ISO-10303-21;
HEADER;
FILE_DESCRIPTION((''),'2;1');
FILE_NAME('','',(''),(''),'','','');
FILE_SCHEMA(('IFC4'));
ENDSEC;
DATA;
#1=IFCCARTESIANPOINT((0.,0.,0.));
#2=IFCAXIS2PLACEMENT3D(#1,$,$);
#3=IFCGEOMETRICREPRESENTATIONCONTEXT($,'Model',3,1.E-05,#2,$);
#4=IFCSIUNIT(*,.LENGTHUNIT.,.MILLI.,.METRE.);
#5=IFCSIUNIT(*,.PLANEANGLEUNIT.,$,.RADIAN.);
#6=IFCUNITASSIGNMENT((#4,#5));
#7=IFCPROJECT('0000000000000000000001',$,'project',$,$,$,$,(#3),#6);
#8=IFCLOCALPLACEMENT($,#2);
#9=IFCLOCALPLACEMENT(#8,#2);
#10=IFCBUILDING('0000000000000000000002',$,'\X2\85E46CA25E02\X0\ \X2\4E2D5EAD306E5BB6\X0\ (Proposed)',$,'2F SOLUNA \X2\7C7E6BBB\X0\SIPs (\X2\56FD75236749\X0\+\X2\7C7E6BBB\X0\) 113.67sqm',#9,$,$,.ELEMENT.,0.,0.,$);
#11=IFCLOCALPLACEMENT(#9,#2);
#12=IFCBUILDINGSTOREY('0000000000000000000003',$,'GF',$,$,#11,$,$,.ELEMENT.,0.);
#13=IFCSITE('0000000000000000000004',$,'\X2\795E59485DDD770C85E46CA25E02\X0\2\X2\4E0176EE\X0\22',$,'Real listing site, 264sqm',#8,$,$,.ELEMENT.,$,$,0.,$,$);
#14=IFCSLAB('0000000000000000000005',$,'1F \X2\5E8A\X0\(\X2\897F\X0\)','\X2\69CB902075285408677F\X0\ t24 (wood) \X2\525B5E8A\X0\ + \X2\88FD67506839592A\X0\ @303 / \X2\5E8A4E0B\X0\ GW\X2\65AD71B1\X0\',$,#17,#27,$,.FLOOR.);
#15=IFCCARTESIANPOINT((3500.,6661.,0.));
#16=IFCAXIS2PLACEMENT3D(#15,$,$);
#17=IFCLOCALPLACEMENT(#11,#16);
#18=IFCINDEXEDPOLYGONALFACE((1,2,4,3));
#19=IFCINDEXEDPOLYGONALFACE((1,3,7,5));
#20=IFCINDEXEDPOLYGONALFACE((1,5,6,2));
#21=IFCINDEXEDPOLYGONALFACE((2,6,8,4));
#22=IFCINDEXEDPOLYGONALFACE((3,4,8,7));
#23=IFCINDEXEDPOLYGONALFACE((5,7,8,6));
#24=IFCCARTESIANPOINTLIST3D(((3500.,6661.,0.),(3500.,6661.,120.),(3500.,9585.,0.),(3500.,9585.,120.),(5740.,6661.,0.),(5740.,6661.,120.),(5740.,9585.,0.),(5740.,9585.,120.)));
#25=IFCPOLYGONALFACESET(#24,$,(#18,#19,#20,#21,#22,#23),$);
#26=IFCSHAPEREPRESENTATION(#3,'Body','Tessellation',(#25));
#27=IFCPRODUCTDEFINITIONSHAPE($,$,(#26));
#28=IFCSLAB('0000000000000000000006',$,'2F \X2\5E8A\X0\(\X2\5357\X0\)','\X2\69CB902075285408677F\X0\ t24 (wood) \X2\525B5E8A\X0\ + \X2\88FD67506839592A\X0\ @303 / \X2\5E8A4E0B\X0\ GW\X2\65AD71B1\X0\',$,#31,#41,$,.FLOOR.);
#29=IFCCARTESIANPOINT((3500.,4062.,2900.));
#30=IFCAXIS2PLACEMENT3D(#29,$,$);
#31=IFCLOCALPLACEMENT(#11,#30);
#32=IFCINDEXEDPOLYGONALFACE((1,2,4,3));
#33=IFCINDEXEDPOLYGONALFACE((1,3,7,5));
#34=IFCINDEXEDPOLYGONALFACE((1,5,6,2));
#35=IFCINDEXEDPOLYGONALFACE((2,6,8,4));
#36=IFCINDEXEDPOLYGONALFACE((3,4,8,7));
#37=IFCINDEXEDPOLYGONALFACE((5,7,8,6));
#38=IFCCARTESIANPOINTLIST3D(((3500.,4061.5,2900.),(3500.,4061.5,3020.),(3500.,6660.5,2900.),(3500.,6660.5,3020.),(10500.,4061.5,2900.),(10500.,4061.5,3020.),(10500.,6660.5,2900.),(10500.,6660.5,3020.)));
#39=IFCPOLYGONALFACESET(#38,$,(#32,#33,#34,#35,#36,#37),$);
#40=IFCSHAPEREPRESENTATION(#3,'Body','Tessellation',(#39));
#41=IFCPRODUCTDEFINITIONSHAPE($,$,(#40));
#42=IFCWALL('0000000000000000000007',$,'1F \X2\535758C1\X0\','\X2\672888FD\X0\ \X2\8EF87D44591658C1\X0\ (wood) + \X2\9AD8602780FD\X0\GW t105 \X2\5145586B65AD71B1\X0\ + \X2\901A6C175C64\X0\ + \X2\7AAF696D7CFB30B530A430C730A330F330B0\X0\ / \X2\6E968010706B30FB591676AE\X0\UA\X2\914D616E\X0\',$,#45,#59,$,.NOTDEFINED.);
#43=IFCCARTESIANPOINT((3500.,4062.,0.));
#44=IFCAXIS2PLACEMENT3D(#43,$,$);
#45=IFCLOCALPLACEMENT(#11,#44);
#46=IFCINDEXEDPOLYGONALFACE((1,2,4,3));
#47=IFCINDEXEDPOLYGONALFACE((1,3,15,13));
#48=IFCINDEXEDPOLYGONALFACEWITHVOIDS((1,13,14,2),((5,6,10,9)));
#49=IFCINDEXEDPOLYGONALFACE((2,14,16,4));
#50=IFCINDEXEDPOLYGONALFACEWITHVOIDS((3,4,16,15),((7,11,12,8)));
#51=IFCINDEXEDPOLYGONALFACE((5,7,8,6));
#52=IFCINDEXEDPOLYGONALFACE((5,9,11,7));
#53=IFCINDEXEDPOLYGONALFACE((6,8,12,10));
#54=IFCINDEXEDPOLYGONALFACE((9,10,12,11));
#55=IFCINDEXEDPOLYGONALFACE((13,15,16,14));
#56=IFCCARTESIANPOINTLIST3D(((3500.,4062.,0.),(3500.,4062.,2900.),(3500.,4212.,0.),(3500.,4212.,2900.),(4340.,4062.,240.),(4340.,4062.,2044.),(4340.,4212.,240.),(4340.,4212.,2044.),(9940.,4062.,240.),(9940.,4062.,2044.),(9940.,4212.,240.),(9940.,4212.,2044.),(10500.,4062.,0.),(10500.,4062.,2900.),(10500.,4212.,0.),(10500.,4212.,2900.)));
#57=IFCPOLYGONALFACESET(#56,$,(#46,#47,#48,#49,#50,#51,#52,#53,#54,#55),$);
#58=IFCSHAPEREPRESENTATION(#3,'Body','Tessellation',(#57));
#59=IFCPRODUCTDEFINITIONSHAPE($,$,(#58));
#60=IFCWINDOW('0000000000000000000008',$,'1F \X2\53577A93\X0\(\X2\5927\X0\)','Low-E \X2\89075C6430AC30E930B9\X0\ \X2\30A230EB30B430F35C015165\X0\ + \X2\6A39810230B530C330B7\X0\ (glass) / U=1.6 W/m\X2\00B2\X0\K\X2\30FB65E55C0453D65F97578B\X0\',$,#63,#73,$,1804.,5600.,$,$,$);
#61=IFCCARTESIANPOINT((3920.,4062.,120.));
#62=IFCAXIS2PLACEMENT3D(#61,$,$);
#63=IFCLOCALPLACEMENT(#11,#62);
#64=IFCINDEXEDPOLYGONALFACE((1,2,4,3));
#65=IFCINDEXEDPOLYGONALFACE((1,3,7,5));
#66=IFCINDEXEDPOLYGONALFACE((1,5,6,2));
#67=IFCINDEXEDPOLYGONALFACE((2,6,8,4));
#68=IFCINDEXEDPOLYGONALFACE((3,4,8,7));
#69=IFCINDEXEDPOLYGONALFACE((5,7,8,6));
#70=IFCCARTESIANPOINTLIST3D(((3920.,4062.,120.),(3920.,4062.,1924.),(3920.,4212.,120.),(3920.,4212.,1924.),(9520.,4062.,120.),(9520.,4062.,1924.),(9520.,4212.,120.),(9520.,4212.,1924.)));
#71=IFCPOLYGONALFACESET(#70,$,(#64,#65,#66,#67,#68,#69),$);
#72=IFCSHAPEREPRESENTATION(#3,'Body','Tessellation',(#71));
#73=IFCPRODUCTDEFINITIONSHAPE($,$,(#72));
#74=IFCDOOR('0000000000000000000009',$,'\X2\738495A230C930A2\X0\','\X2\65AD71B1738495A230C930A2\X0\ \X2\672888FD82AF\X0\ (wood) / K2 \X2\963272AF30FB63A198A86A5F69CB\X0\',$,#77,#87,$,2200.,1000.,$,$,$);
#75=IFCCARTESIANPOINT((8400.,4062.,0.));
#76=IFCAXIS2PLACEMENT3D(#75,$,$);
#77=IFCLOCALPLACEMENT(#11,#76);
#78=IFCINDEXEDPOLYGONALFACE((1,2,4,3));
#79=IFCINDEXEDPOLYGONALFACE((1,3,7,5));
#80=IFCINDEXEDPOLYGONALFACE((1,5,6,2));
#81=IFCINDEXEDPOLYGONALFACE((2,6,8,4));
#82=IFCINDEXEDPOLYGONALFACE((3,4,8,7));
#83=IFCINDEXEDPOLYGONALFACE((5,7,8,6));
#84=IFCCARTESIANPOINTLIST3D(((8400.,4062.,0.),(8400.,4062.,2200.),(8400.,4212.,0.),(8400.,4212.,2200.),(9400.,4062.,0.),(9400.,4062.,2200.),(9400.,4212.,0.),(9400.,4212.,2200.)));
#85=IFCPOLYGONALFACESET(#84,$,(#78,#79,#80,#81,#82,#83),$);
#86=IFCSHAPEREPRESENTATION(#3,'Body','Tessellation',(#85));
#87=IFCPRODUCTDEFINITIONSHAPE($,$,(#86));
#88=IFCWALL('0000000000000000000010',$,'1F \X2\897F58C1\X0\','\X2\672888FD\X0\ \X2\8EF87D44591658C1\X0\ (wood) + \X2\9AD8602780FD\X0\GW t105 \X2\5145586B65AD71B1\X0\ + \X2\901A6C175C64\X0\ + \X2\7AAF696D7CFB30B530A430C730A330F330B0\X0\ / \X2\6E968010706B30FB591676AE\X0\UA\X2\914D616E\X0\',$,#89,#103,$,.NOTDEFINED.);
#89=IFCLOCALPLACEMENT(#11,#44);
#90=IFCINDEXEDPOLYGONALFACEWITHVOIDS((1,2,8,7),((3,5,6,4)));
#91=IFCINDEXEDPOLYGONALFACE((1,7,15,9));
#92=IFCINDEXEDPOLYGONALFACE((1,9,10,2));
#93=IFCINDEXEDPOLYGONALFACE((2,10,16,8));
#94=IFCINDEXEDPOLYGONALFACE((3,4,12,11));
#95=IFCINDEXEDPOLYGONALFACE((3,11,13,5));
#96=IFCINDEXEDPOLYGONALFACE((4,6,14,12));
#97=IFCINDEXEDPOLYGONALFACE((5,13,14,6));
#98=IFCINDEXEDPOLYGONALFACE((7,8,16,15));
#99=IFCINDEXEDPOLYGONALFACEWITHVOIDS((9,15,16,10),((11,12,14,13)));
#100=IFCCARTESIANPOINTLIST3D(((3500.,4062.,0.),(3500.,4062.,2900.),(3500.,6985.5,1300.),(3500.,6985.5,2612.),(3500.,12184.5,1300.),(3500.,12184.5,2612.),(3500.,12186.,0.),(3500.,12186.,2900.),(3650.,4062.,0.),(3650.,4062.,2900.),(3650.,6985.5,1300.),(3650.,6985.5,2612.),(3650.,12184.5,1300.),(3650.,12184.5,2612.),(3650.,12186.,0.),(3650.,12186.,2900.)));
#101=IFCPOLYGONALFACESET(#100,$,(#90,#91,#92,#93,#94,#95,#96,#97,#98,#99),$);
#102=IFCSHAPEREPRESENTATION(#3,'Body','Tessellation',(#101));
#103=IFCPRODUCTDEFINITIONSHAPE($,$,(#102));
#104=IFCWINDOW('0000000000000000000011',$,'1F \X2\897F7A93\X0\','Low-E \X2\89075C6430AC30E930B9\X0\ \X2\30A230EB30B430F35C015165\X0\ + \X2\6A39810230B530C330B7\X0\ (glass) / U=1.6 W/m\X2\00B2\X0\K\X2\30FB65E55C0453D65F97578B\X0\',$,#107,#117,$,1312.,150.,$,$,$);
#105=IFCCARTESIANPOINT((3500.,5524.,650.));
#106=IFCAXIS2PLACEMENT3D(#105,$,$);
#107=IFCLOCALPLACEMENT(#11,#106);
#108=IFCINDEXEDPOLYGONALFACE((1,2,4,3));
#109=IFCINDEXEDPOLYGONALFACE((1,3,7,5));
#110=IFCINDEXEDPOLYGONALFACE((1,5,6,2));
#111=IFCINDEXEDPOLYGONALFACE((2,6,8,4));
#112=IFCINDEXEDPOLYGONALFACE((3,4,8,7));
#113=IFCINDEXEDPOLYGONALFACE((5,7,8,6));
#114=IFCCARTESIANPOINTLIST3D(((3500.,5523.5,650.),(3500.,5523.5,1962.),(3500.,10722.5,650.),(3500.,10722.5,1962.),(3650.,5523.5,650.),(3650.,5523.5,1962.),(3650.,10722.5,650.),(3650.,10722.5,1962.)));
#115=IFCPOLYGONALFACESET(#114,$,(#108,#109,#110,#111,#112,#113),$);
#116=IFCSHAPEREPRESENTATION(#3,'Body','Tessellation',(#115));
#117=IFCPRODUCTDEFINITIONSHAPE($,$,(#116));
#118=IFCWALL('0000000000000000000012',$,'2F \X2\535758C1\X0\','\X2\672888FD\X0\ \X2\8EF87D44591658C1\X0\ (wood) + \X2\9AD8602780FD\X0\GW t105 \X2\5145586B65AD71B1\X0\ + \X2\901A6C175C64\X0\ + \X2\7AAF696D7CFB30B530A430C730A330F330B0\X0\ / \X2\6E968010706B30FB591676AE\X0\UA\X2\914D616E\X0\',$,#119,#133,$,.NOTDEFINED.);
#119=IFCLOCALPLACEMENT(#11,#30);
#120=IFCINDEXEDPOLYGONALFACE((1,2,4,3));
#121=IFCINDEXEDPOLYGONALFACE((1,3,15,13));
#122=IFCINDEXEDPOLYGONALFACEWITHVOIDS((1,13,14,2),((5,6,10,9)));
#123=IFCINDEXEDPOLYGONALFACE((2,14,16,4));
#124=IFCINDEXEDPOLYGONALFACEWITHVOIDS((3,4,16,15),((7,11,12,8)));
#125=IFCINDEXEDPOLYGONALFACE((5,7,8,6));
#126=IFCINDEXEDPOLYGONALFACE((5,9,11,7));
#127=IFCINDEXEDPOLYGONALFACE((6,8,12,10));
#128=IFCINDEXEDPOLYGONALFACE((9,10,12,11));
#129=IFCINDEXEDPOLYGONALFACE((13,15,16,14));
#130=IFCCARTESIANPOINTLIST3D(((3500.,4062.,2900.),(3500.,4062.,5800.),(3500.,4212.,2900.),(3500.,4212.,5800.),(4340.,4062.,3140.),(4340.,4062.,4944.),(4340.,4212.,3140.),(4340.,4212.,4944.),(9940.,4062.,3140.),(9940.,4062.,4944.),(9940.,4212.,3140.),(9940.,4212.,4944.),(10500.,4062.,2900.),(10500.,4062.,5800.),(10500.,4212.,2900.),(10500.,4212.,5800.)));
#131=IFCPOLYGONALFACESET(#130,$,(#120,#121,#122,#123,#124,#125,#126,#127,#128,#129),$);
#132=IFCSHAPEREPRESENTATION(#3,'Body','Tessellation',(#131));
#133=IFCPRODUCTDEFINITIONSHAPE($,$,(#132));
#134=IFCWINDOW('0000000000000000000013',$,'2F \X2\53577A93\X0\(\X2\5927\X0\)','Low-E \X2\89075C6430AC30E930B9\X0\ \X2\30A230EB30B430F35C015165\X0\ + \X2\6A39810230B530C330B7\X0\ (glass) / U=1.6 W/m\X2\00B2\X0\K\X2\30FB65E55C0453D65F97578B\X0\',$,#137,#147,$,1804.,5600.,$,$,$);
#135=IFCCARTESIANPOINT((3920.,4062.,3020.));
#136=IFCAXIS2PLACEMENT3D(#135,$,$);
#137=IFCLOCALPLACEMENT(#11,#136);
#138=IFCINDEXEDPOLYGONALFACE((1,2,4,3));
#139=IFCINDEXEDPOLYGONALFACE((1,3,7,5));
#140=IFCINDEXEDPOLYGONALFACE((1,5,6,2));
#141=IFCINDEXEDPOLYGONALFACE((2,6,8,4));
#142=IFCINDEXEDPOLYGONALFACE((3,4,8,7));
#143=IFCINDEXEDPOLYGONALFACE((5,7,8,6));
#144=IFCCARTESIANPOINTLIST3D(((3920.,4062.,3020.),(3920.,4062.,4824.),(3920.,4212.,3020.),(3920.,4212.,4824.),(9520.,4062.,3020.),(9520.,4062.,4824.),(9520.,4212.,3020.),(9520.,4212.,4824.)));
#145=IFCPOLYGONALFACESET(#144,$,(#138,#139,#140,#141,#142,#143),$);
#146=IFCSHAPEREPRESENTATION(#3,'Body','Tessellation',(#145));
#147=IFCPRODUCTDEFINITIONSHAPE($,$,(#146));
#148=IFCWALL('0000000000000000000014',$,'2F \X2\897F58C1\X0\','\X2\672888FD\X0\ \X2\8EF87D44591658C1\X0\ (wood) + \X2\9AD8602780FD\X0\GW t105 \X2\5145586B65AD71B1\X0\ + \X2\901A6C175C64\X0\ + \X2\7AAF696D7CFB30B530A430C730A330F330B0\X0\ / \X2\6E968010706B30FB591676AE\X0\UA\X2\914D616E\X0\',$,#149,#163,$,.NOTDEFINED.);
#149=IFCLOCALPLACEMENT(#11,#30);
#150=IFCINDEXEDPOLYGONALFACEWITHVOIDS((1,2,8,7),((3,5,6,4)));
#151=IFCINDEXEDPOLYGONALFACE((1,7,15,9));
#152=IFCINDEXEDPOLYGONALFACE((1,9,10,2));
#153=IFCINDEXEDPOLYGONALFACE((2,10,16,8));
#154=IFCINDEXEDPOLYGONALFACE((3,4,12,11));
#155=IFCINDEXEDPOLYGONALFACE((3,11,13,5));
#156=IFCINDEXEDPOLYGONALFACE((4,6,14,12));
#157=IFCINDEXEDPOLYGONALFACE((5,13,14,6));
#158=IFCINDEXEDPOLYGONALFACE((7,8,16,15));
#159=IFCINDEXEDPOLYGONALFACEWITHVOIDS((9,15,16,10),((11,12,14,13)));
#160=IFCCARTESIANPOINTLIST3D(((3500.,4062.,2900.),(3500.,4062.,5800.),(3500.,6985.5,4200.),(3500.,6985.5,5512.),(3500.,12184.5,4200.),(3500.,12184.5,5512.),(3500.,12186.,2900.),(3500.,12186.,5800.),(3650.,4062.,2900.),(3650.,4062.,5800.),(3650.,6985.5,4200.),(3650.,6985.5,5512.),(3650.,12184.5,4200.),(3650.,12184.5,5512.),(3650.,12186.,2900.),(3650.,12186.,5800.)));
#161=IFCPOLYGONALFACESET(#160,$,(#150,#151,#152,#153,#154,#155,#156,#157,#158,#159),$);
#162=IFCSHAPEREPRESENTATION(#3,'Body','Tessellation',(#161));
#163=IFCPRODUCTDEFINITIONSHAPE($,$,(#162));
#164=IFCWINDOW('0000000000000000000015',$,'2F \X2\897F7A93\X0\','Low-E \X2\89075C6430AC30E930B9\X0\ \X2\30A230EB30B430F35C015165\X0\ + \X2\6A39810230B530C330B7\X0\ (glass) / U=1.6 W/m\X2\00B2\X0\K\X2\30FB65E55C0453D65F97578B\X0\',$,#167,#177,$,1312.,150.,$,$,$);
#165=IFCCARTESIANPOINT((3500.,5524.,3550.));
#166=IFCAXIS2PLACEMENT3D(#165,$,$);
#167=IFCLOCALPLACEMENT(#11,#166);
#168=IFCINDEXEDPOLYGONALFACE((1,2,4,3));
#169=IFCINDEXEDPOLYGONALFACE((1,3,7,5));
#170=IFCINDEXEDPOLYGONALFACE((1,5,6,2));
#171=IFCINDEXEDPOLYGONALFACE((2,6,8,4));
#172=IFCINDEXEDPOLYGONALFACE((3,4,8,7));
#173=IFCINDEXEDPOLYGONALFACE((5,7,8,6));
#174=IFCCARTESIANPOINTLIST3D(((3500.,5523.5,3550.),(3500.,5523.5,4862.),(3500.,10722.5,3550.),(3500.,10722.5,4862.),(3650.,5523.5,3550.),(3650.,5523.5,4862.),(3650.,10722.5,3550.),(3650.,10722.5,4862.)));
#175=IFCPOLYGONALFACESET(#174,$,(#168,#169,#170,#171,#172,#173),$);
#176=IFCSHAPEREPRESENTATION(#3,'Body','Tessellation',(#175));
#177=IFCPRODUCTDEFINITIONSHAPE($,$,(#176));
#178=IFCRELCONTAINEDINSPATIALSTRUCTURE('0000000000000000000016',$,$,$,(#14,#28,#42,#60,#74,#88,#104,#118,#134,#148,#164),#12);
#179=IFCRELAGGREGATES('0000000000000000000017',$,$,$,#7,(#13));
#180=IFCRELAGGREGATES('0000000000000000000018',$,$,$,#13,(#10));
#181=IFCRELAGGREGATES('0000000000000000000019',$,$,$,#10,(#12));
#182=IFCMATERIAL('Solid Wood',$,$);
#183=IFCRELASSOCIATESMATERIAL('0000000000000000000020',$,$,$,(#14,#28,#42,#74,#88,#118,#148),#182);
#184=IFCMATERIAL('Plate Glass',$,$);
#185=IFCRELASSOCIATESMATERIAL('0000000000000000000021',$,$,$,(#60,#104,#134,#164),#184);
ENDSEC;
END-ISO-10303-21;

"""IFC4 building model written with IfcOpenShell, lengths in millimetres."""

from ifc_helpers import new_model, si_unit, frame, frame_2d, origin, place, context, project, spatial, rectangle, extrude, material, element, fill, save


model = new_model("IFC4")

# Units and contexts
model_context = context("Model", 3, precision=1e-05, world=origin())
ifc_project = project(units=[si_unit("LENGTHUNIT", "METRE", prefix="MILLI"), si_unit("PLANEANGLEUNIT", "RADIAN")], contexts=[model_context])

# Site, building, storey
site_placement = place(None, origin())
site = spatial("IfcSite", under=ifc_project, at=site_placement, Name="神奈川県藤沢市2丁目22", ObjectType="Real listing site, 264sqm", CompositionType="ELEMENT", RefElevation=0.0)
building_placement = place(site_placement, origin())
building = spatial("IfcBuilding", under=site, at=building_placement, Name="藤沢市 中庭の家 (Proposed)", ObjectType="2F SOLUNA 籾殻SIPs (国産杉+籾殻) 113.67sqm", CompositionType="ELEMENT", ElevationOfRefHeight=0.0, ElevationOfTerrain=0.0)
storey_placement = place(building_placement, origin())
storey = spatial("IfcBuildingStorey", under=building, at=storey_placement, Name="GF", CompositionType="ELEMENT", Elevation=0.0)

# Slabs
ifc_material_1 = material(Name="Solid Wood")
slab_1_placement = place(storey_placement, frame((3500.0, 6661.0, 0.0)))
element("IfcSlab", 1, at=slab_1_placement, inside=storey, material=ifc_material_1, Name="1F 床(西)", Description="構造用合板 t24 (wood) 剛床 + 製材根太 @303 / 床下 GW断熱", PredefinedType="FLOOR", context=model_context, shape_type="SweptSolid", body=[
    extrude(rectangle(XDim=2240.0, YDim=2924.0, at=frame_2d((1120.0, 1462.0))), frame((3500.0, 6661.0, 0.0)), (0.0, 0.0, 1.0), 120.0),
])
slab_2_placement = place(storey_placement, frame((3500.0, 4062.0, 2900.0)))
element("IfcSlab", 2, at=slab_2_placement, inside=storey, material=ifc_material_1, Name="2F 床(南)", Description="構造用合板 t24 (wood) 剛床 + 製材根太 @303 / 床下 GW断熱", PredefinedType="FLOOR", context=model_context, shape_type="SweptSolid", body=[
    extrude(rectangle(XDim=7000.0, YDim=2599.0, at=frame_2d((3500.0, 1299.0))), frame((3500.0, 4062.0, 2900.0)), (0.0, 0.0, 1.0), 120.0),
])

# Wall, openings, window, door
wall_1_placement = place(storey_placement, frame((3500.0, 4062.0, 0.0)))
wall_1 = element("IfcWall", 3, at=wall_1_placement, inside=storey, material=ifc_material_1, Name="1F 南壁", Description="木製 軸組外壁 (wood) + 高性能GW t105 充填断熱 + 通気層 + 窯業系サイディング / 準耐火・外皮UA配慮", PredefinedType="NOTDEFINED", context=model_context, shape_type="SweptSolid", body=[
    extrude(rectangle(XDim=7000.0, YDim=150.0, at=frame_2d((3500.0, 75.0))), frame((3500.0, 4062.0, 0.0)), (0.0, 0.0, 1.0), 2900.0),
])
opening_1_placement = place(storey_placement, frame((3920.0, 4062.0, 120.0)))
opening_1 = element("IfcOpeningElement", 4, at=opening_1_placement, cuts=wall_1, PredefinedType="NOTDEFINED", context=model_context, shape_type="SweptSolid", body=[
    extrude(rectangle(XDim=5600.0, YDim=150.0, at=frame_2d((2800.0, 75.0))), frame((3920.0, 4062.0, 120.0)), (0.0, 0.0, 1.0), 1804.0),
])
opening_2_placement = place(storey_placement, frame((8400.0, 4062.0, 0.0)))
opening_2 = element("IfcOpeningElement", 5, at=opening_2_placement, cuts=wall_1, PredefinedType="NOTDEFINED", context=model_context, shape_type="SweptSolid", body=[
    extrude(rectangle(XDim=1000.0, YDim=150.0, at=frame_2d((500.0, 75.0))), frame((8400.0, 4062.0, 0.0)), (0.0, 0.0, 1.0), 2200.0),
])
ifc_material_2 = material(Name="Plate Glass")
window_1_placement = place(storey_placement, frame((3920.0, 4062.0, 120.0)))
window_1 = element("IfcWindow", 6, at=window_1_placement, inside=storey, material=ifc_material_2, Name="1F 南窓(大)", Description="Low-E 複層ガラス アルゴン封入 + 樹脂サッシ (glass) / U=1.6 W/m²K・日射取得型", OverallHeight=1804.0, OverallWidth=5600.0, context=model_context, shape_type="SweptSolid", body=[
    extrude(rectangle(XDim=5600.0, YDim=150.0, at=frame_2d((2800.0, 75.0))), frame((3920.0, 4062.0, 120.0)), (0.0, 0.0, 1.0), 1804.0),
])
fill(opening_1, window_1)
door_placement = place(storey_placement, frame((8400.0, 4062.0, 0.0)))
door = element("IfcDoor", 7, at=door_placement, inside=storey, material=ifc_material_1, Name="玄関ドア", Description="断熱玄関ドア 木製芯 (wood) / K2 防犯・採風機構", OverallHeight=2200.0, OverallWidth=1000.0, context=model_context, shape_type="SweptSolid", body=[
    extrude(rectangle(XDim=1000.0, YDim=150.0, at=frame_2d((500.0, 75.0))), frame((8400.0, 4062.0, 0.0)), (0.0, 0.0, 1.0), 2200.0),
])
fill(opening_2, door)

# Walls, openings, windows
wall_2_placement = place(storey_placement, frame((3500.0, 4062.0, 0.0)))
wall_2 = element("IfcWall", 8, at=wall_2_placement, inside=storey, material=ifc_material_1, Name="1F 西壁", Description="木製 軸組外壁 (wood) + 高性能GW t105 充填断熱 + 通気層 + 窯業系サイディング / 準耐火・外皮UA配慮", PredefinedType="NOTDEFINED", context=model_context, shape_type="SweptSolid", body=[
    extrude(rectangle(XDim=150.0, YDim=8124.0, at=frame_2d((75.0, 4062.0))), frame((3500.0, 4062.0, 0.0)), (0.0, 0.0, 1.0), 2900.0),
])
opening_3_placement = place(storey_placement, frame((3500.0, 5524.0, 650.0)))
opening_3 = element("IfcOpeningElement", 9, at=opening_3_placement, cuts=wall_2, PredefinedType="NOTDEFINED", context=model_context, shape_type="SweptSolid", body=[
    extrude(rectangle(XDim=150.0, YDim=5199.0, at=frame_2d((75.0, 2599.0))), frame((3500.0, 5524.0, 650.0)), (0.0, 0.0, 1.0), 1312.0),
])
window_2_placement = place(storey_placement, frame((3500.0, 5524.0, 650.0)))
window_2 = element("IfcWindow", 10, at=window_2_placement, inside=storey, material=ifc_material_2, Name="1F 西窓", Description="Low-E 複層ガラス アルゴン封入 + 樹脂サッシ (glass) / U=1.6 W/m²K・日射取得型", OverallHeight=1312.0, OverallWidth=150.0, context=model_context, shape_type="SweptSolid", body=[
    extrude(rectangle(XDim=150.0, YDim=5199.0, at=frame_2d((75.0, 2599.0))), frame((3500.0, 5524.0, 650.0)), (0.0, 0.0, 1.0), 1312.0),
])
fill(opening_3, window_2)
wall_3_placement = place(storey_placement, frame((3500.0, 4062.0, 2900.0)))
wall_3 = element("IfcWall", 11, at=wall_3_placement, inside=storey, material=ifc_material_1, Name="2F 南壁", Description="木製 軸組外壁 (wood) + 高性能GW t105 充填断熱 + 通気層 + 窯業系サイディング / 準耐火・外皮UA配慮", PredefinedType="NOTDEFINED", context=model_context, shape_type="SweptSolid", body=[
    extrude(rectangle(XDim=7000.0, YDim=150.0, at=frame_2d((3500.0, 75.0))), frame((3500.0, 4062.0, 2900.0)), (0.0, 0.0, 1.0), 2900.0),
])
opening_4_placement = place(storey_placement, frame((3920.0, 4062.0, 3020.0)))
opening_4 = element("IfcOpeningElement", 12, at=opening_4_placement, cuts=wall_3, PredefinedType="NOTDEFINED", context=model_context, shape_type="SweptSolid", body=[
    extrude(rectangle(XDim=5600.0, YDim=150.0, at=frame_2d((2800.0, 75.0))), frame((3920.0, 4062.0, 3020.0)), (0.0, 0.0, 1.0), 1804.0),
])
window_3_placement = place(storey_placement, frame((3920.0, 4062.0, 3020.0)))
window_3 = element("IfcWindow", 13, at=window_3_placement, inside=storey, material=ifc_material_2, Name="2F 南窓(大)", Description="Low-E 複層ガラス アルゴン封入 + 樹脂サッシ (glass) / U=1.6 W/m²K・日射取得型", OverallHeight=1804.0, OverallWidth=5600.0, context=model_context, shape_type="SweptSolid", body=[
    extrude(rectangle(XDim=5600.0, YDim=150.0, at=frame_2d((2800.0, 75.0))), frame((3920.0, 4062.0, 3020.0)), (0.0, 0.0, 1.0), 1804.0),
])
fill(opening_4, window_3)
wall_4_placement = place(storey_placement, frame((3500.0, 4062.0, 2900.0)))
wall_4 = element("IfcWall", 14, at=wall_4_placement, inside=storey, material=ifc_material_1, Name="2F 西壁", Description="木製 軸組外壁 (wood) + 高性能GW t105 充填断熱 + 通気層 + 窯業系サイディング / 準耐火・外皮UA配慮", PredefinedType="NOTDEFINED", context=model_context, shape_type="SweptSolid", body=[
    extrude(rectangle(XDim=150.0, YDim=8124.0, at=frame_2d((75.0, 4062.0))), frame((3500.0, 4062.0, 2900.0)), (0.0, 0.0, 1.0), 2900.0),
])
opening_5_placement = place(storey_placement, frame((3500.0, 5524.0, 3550.0)))
opening_5 = element("IfcOpeningElement", 15, at=opening_5_placement, cuts=wall_4, PredefinedType="NOTDEFINED", context=model_context, shape_type="SweptSolid", body=[
    extrude(rectangle(XDim=150.0, YDim=5199.0, at=frame_2d((75.0, 2599.0))), frame((3500.0, 5524.0, 3550.0)), (0.0, 0.0, 1.0), 1312.0),
])
window_4_placement = place(storey_placement, frame((3500.0, 5524.0, 3550.0)))
window_4 = element("IfcWindow", 16, at=window_4_placement, inside=storey, material=ifc_material_2, Name="2F 西窓", Description="Low-E 複層ガラス アルゴン封入 + 樹脂サッシ (glass) / U=1.6 W/m²K・日射取得型", OverallHeight=1312.0, OverallWidth=150.0, context=model_context, shape_type="SweptSolid", body=[
    extrude(rectangle(XDim=150.0, YDim=5199.0, at=frame_2d((75.0, 2599.0))), frame((3500.0, 5524.0, 3550.0)), (0.0, 0.0, 1.0), 1312.0),
])
fill(opening_5, window_4)

save(model, "model.ifc")
